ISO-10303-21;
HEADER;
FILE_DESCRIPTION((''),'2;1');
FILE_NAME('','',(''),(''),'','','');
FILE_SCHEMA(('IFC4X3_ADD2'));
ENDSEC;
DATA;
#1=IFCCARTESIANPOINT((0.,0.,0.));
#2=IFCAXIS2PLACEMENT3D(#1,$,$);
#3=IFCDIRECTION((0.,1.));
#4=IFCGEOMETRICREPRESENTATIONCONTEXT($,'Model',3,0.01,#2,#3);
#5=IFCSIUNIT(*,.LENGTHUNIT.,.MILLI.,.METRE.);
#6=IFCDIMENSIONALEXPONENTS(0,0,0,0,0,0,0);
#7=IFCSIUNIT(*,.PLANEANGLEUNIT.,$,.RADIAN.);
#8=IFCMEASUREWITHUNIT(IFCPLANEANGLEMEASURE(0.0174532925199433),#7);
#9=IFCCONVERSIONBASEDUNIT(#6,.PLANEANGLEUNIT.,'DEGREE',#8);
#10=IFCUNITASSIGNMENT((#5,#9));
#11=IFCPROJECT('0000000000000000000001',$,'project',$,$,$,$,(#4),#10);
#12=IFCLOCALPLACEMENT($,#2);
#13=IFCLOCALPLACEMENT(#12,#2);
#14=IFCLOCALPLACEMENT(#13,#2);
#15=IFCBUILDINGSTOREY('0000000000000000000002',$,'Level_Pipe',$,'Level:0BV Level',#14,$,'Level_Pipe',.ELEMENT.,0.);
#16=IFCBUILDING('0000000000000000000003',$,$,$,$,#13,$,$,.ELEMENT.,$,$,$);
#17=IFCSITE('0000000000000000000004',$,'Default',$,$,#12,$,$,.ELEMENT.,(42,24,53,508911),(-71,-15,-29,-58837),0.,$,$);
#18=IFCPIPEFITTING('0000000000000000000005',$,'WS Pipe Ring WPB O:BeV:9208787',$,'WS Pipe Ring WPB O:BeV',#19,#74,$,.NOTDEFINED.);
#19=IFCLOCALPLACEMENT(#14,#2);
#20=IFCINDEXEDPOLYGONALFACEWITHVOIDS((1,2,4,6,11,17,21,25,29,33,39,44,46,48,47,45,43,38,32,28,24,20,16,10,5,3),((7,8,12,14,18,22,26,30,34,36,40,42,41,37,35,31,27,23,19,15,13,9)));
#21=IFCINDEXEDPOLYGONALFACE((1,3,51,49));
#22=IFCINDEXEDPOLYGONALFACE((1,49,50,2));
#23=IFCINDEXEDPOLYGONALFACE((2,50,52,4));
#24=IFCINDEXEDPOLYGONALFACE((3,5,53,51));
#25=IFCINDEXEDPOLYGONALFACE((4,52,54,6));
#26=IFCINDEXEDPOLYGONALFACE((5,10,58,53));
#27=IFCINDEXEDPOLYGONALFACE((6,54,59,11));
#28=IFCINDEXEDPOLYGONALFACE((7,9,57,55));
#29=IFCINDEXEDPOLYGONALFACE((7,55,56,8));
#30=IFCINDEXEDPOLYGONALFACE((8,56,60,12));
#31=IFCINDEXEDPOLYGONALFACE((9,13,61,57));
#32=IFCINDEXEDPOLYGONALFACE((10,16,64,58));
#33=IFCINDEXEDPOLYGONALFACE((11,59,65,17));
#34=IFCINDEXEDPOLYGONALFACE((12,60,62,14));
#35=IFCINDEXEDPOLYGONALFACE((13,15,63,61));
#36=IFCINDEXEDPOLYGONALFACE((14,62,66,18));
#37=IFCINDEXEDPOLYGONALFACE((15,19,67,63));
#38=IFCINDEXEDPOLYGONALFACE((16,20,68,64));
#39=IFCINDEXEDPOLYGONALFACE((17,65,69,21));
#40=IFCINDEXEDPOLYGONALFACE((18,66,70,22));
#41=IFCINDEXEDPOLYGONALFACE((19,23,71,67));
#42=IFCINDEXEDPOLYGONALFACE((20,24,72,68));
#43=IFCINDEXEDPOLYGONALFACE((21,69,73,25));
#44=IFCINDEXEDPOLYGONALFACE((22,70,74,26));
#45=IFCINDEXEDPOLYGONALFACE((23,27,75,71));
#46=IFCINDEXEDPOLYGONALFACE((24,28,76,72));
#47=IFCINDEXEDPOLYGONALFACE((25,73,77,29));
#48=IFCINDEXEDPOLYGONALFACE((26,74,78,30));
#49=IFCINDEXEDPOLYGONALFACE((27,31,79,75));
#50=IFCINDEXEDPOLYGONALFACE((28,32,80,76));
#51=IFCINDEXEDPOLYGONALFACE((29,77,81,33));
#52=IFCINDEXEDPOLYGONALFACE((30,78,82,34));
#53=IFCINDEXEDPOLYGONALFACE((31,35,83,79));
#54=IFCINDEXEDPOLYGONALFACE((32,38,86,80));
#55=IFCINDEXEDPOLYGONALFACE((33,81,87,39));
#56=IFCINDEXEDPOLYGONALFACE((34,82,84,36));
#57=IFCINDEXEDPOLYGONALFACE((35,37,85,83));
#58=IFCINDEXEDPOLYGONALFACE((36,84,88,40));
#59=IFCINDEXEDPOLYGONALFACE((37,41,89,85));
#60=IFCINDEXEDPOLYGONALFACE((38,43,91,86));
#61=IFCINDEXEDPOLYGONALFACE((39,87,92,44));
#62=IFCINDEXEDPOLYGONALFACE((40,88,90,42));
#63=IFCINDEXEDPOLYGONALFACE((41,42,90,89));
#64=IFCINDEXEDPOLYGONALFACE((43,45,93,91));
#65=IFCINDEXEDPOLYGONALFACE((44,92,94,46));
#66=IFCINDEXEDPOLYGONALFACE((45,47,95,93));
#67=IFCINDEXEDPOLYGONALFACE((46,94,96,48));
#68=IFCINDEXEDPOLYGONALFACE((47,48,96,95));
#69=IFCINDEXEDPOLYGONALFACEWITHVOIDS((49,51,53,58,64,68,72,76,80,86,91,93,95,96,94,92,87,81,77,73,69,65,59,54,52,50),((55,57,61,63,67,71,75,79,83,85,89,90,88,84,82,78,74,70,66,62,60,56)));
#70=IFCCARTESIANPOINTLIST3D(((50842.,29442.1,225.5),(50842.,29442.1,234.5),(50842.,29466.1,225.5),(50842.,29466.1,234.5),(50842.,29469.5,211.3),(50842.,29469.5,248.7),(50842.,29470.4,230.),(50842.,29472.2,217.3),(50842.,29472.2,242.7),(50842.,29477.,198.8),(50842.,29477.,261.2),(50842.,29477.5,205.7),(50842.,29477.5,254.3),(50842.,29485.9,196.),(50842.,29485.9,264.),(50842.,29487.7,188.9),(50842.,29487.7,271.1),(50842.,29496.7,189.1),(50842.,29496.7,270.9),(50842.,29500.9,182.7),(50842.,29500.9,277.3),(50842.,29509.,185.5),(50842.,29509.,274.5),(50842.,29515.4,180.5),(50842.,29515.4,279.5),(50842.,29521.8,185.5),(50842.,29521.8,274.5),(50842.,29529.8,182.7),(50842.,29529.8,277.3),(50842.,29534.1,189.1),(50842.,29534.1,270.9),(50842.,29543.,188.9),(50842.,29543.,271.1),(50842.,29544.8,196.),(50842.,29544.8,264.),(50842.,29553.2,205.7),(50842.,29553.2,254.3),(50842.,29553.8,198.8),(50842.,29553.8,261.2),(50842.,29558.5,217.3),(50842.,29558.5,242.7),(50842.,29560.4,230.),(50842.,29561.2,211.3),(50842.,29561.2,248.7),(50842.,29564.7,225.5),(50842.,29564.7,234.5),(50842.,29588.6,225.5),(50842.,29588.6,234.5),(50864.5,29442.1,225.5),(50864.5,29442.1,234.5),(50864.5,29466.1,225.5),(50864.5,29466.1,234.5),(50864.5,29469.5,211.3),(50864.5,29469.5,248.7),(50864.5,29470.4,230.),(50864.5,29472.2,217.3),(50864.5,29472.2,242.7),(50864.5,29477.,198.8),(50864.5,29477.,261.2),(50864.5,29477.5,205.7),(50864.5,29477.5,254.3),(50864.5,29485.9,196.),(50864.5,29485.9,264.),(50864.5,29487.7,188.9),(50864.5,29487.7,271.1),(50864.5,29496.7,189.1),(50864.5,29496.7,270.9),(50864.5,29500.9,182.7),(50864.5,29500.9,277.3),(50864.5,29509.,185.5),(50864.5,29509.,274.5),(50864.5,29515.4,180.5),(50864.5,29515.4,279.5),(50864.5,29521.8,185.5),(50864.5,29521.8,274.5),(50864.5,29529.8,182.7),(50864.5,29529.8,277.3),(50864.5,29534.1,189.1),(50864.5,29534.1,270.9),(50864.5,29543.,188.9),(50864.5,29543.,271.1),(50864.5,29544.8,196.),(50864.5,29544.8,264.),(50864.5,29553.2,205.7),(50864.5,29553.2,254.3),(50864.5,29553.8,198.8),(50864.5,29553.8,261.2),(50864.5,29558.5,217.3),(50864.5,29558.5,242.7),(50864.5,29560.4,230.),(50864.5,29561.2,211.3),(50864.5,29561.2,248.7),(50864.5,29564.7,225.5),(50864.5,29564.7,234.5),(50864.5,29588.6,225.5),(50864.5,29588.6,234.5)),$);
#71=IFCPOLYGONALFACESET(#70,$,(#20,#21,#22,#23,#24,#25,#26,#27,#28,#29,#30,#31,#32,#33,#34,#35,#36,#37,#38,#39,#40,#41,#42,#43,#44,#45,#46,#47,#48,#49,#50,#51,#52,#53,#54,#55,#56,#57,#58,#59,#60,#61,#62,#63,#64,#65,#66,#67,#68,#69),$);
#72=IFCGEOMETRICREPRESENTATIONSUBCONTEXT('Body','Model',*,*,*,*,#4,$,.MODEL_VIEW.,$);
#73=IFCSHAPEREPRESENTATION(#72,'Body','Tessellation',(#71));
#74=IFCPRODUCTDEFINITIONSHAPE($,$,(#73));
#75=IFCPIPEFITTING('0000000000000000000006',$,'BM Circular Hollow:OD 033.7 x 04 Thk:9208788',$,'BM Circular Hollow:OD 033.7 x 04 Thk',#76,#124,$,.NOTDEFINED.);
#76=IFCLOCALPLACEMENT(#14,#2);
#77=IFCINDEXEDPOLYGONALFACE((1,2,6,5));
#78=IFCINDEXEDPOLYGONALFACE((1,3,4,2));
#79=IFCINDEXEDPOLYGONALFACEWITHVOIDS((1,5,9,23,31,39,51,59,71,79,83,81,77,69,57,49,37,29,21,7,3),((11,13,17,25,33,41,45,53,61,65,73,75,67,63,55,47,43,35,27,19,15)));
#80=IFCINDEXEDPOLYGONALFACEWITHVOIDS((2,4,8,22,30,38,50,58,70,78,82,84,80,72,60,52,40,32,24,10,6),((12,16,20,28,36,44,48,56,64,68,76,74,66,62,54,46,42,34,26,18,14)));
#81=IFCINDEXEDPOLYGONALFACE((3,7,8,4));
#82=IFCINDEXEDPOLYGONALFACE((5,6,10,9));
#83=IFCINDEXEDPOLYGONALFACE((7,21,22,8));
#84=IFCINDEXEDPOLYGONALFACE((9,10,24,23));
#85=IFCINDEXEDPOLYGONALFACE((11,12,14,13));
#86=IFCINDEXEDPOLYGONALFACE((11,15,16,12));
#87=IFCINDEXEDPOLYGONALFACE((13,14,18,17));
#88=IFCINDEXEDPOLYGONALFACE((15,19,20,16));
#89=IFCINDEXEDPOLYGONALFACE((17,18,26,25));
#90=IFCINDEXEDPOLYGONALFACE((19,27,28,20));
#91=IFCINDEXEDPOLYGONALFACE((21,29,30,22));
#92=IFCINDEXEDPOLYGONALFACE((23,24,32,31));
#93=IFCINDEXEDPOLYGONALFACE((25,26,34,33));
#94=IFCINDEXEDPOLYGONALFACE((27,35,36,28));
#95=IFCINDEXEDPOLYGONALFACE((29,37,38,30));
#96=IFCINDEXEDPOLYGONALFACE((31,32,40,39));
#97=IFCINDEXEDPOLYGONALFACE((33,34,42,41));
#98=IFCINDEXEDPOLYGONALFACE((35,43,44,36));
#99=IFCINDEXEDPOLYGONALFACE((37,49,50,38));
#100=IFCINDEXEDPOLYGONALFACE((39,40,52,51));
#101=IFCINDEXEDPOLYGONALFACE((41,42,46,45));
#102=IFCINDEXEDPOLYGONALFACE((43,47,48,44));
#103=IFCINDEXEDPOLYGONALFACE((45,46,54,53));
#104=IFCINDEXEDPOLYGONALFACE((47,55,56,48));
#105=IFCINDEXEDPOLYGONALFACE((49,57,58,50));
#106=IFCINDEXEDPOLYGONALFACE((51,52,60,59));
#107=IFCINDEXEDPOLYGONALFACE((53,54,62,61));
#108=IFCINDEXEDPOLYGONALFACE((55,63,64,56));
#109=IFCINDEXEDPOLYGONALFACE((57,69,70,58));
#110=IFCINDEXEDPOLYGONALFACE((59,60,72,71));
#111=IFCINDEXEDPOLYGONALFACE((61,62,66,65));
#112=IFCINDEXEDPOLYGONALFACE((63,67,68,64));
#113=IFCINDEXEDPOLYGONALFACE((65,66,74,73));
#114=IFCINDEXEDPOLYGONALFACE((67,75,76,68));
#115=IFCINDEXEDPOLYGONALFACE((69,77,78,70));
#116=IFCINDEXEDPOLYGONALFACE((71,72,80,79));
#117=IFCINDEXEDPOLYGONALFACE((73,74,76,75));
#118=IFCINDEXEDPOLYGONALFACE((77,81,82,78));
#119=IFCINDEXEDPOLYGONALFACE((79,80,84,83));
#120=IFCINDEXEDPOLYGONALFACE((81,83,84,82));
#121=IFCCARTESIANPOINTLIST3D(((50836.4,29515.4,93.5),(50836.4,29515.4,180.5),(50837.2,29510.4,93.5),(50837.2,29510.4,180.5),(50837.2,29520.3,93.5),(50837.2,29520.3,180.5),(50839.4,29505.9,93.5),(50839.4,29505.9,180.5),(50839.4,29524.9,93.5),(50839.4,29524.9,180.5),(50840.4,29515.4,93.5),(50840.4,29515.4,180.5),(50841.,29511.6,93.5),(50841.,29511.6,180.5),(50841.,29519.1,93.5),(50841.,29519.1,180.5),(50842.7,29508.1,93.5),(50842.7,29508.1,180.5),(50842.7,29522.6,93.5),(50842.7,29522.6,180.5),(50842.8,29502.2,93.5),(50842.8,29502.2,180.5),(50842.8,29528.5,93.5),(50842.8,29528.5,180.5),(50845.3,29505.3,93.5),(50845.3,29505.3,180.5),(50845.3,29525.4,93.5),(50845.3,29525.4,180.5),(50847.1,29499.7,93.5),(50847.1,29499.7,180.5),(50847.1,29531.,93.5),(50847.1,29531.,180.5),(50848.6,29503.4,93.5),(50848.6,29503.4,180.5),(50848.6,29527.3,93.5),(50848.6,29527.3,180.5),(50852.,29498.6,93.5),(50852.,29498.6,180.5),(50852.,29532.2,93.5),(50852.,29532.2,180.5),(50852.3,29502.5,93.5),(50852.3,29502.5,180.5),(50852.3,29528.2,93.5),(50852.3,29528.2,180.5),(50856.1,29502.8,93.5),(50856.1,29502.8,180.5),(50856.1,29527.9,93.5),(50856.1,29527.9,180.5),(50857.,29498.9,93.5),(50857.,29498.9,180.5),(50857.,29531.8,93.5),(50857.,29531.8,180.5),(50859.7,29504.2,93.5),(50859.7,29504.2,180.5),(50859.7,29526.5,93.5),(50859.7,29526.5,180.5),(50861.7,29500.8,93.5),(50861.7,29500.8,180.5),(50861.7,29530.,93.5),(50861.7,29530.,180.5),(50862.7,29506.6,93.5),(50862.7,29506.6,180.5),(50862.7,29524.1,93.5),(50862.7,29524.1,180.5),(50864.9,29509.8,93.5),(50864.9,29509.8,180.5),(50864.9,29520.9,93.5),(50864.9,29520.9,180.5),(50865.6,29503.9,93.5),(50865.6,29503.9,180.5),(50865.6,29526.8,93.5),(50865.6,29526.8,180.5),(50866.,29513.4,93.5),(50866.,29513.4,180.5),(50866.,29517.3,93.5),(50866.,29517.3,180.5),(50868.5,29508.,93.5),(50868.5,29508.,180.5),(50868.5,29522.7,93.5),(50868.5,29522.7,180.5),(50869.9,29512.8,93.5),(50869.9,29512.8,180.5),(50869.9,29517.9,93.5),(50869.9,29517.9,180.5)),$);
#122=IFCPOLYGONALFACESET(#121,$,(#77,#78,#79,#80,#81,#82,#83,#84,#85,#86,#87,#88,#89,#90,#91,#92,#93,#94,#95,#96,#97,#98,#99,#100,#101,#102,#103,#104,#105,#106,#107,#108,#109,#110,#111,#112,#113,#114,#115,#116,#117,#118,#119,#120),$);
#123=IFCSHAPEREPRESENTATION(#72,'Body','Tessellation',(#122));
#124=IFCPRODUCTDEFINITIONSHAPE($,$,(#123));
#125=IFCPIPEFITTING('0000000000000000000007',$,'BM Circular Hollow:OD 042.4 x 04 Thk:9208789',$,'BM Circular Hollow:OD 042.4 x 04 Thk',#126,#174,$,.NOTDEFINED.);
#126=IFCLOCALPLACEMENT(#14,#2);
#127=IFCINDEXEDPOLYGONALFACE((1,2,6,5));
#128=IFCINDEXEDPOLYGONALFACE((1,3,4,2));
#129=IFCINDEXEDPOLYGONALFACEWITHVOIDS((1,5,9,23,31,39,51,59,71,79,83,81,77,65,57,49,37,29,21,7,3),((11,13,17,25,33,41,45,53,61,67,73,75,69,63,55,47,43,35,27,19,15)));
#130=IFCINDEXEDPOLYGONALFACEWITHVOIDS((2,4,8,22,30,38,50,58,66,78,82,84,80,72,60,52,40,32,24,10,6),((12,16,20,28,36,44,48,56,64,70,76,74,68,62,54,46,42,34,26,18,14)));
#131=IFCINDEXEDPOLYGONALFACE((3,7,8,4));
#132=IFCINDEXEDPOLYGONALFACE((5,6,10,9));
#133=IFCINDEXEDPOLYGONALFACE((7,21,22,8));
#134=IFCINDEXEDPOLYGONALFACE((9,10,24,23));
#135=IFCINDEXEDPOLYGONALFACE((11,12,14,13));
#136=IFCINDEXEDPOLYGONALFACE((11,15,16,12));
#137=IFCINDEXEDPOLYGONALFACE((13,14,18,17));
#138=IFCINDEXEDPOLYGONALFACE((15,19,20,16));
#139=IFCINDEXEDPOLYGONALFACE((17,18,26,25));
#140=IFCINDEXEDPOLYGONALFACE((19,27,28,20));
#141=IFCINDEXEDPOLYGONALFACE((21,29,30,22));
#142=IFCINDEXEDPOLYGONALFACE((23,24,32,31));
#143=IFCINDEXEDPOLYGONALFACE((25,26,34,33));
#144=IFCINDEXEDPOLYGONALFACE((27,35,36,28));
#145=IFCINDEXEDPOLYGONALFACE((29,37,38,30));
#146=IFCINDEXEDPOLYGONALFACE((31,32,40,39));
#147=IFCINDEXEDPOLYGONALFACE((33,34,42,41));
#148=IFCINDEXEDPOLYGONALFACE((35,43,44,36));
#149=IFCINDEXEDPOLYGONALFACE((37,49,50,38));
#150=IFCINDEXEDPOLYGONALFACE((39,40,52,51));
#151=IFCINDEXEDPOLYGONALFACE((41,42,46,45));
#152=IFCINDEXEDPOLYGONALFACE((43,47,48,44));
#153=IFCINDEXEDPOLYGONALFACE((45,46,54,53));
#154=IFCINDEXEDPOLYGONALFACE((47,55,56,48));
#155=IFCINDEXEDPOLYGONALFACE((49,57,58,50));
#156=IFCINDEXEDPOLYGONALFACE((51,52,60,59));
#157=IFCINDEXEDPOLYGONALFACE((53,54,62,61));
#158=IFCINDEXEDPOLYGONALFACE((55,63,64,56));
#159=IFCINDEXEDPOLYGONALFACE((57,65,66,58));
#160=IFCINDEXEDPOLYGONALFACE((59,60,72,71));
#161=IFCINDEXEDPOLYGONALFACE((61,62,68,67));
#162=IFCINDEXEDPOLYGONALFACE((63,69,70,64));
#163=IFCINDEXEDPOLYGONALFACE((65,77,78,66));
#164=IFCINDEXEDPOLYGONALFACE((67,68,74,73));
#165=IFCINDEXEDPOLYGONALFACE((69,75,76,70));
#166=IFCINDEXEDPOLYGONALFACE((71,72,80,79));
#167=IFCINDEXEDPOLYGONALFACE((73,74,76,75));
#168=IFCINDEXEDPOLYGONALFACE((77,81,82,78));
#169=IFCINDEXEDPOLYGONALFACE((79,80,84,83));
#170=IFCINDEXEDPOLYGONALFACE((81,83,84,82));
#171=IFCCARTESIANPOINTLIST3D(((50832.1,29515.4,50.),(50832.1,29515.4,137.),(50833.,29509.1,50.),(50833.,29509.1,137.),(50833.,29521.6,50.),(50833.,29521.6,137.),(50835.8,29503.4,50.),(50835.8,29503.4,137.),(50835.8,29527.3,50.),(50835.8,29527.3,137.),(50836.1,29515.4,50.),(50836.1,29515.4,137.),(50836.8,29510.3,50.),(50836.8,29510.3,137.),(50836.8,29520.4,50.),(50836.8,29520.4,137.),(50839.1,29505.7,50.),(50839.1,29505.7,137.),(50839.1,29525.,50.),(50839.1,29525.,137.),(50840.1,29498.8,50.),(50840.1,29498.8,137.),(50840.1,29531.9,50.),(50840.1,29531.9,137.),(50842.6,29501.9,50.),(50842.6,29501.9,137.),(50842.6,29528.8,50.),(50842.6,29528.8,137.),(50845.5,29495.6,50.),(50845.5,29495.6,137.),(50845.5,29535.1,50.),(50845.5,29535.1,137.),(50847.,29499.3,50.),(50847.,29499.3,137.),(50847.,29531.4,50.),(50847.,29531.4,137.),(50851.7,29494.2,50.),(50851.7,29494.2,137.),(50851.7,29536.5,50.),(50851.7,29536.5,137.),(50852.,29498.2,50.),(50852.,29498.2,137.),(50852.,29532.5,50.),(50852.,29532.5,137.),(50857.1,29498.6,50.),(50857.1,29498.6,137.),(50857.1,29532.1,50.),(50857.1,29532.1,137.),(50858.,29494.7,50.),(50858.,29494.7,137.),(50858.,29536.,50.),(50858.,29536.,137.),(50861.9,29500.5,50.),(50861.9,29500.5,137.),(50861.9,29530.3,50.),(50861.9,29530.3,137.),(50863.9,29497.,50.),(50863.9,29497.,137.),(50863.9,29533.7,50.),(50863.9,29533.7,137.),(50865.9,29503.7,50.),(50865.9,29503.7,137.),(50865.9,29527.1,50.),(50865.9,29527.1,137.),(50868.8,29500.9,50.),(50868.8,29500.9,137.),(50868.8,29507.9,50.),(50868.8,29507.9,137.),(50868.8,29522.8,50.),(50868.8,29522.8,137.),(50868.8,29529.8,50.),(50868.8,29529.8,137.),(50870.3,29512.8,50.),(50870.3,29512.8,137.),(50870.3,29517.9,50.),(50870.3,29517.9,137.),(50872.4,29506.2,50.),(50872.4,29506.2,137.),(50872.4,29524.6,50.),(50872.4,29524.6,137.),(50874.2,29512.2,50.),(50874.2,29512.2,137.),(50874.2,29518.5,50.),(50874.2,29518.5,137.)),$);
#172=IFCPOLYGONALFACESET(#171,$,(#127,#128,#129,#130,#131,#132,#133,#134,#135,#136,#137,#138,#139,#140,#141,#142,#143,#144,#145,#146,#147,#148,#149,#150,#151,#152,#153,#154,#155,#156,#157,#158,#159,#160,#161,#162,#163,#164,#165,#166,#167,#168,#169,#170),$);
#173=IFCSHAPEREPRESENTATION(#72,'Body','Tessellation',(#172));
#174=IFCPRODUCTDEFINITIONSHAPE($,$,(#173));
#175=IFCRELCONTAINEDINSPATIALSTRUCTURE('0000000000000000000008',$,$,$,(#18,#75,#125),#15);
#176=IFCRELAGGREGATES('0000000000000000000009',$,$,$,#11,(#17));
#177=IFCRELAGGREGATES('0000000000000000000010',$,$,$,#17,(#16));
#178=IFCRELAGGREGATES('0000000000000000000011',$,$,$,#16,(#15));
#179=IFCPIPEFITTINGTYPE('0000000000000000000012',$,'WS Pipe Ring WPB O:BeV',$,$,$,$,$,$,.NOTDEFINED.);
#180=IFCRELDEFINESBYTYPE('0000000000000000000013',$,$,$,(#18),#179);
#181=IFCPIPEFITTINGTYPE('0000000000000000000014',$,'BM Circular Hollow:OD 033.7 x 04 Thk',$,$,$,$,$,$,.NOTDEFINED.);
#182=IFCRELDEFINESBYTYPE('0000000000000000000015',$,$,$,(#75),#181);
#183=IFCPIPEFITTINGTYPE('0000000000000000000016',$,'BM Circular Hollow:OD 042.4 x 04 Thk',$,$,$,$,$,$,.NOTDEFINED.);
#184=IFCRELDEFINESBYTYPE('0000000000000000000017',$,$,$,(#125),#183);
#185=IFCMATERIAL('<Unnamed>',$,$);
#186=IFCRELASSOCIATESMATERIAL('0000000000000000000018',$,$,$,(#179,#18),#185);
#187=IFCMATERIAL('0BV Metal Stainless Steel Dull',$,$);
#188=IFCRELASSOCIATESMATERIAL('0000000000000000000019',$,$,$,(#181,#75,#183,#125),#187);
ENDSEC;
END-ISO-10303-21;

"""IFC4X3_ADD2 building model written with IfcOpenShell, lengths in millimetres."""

from ifc_helpers import new_model, entity, si_unit, converted_unit, direction, frame, frame_2d, origin, origin_2d_with_axis, place, context, subcontext, project, spatial, polyline, circle_curve, parameter, trimmed, segment, composite_curve, hollow_circle, outline, extrude, source, transform, mapped, material, type_object, type_shapes, element, save


model = new_model("IFC4X3_ADD2")

# Units and contexts
model_context = context("Model", 3, precision=0.01, world=origin(), true_north=direction((0.0, 1.0)))
body_context = subcontext(model_context, "Body", "Model", "MODEL_VIEW")
ifc_project = project(units=[si_unit("LENGTHUNIT", "METRE", prefix="MILLI"), converted_unit("PLANEANGLEUNIT", "DEGREE", entity("IfcPlaneAngleMeasure", 0.0174532925199433), si_unit("PLANEANGLEUNIT", "RADIAN"), dimensions=[0, 0, 0, 0, 0, 0, 0])], contexts=[model_context])

# Site, building, storey
site_placement = place(None, origin())
site = spatial("IfcSite", under=ifc_project, at=site_placement, Name="Default", CompositionType="ELEMENT", RefLatitude=(42, 24, 53, 508911), RefLongitude=(-71, -15, -29, -58837), RefElevation=0.0)
building_placement = place(site_placement, origin())
building = spatial("IfcBuilding", under=site, at=building_placement, CompositionType="ELEMENT")
storey_placement = place(building_placement, origin())
storey = spatial("IfcBuildingStorey", under=building, at=storey_placement, Name="Level_Pipe", ObjectType="Level:0BV Level", LongName="Level_Pipe", CompositionType="ELEMENT", Elevation=0.0)

# Pipe fittings
ifc_material_1 = material(Name="0BV Metal Stainless Steel Dull")
ifc_material_2 = material(Name="<Unnamed>")
pipe_fitting_type_1 = type_object("IfcPipeFittingType", Name="WS Pipe Ring WPB O:BeV", PredefinedType="NOTDEFINED", material=ifc_material_2)
shared_shape_1 = source(origin(), body_context, "Body", "SweptSolid", [
    extrude(outline(composite_curve([segment(trimmed(circle_curve(origin_2d_with_axis(), 49.5), [parameter(185.215909)], [parameter(354.784091)], True, "PARAMETER"), True, "CONTINUOUS"), segment(polyline([(49.3, -4.5), (73.3, -4.5)]), True, "CONTINUOUS"), segment(polyline([(73.3, -4.5), (73.3, 4.5)]), True, "CONTINUOUS"), segment(polyline([(73.3, 4.5), (49.3, 4.5)]), True, "CONTINUOUS"), segment(trimmed(circle_curve(origin_2d_with_axis(), 49.5), [parameter(5.215909)], [parameter(174.784091)], True, "PARAMETER"), True, "CONTINUOUS"), segment(polyline([(-49.3, 4.5), (-73.3, 4.5)]), True, "CONTINUOUS"), segment(polyline([(-73.3, 4.5), (-73.3, -4.5)]), True, "CONTINUOUS"), segment(polyline([(-73.3, -4.5), (-49.3, -4.5)]), True, "CONTINUOUS")], self_intersect=False), holes=[composite_curve([segment(trimmed(circle_curve(origin_2d_with_axis(), 45.0), [parameter(0.0)], [parameter(180.0)], True, "PARAMETER"), False, "CONTINUOUS"), segment(trimmed(circle_curve(origin_2d_with_axis(), 45.0), [parameter(180.0)], [parameter(360.0)], True, "PARAMETER"), False, "CONTINUOUS")], self_intersect=False)]), frame((0.0, -11.2, 0.0), z_axis=(0.0, 1.0, 0.0), x_axis=(1.0, 0.0, 0.0)), (0.0, 0.0, 1.0), 22.5),
])
type_shapes(pipe_fitting_type_1, [shared_shape_1])
pipe_fitting_1_placement = place(storey_placement, frame((50853.3, 29515.4, 230.0), z_axis=(0.0, 0.0, 1.0), x_axis=(0.0, -1.0, 0.0)))
element("IfcPipeFitting", 1, at=pipe_fitting_1_placement, inside=storey, type_object=pipe_fitting_type_1, material=ifc_material_2, Name="WS Pipe Ring WPB O:BeV:9208787", ObjectType="WS Pipe Ring WPB O:BeV", PredefinedType="NOTDEFINED", context=body_context, shape_type="MappedRepresentation", body=[
    mapped(shared_shape_1, transform((0.0, 0.0, 0.0), scale=1.0)),
])
pipe_fitting_type_2 = type_object("IfcPipeFittingType", Name="BM Circular Hollow:OD 033.7 x 04 Thk", PredefinedType="NOTDEFINED", material=ifc_material_1)
shared_shape_2 = source(origin(), body_context, "Body", "SweptSolid", [
    extrude(hollow_circle(Radius=16.9, WallThickness=4.0, at=frame_2d((0.0, 0.0), x_axis=(1.0, 0.0))), frame((-43.5, 0.0, 0.0), z_axis=(1.0, 0.0, 0.0), x_axis=(0.0, -1.0, 0.0)), (0.0, 0.0, 1.0), 87.0),
])
type_shapes(pipe_fitting_type_2, [shared_shape_2])
pipe_fitting_2_placement = place(storey_placement, frame((50853.3, 29515.4, 137.0), z_axis=(0.0, 1.0, 0.0), x_axis=(0.0, 0.0, 1.0)))
element("IfcPipeFitting", 2, at=pipe_fitting_2_placement, inside=storey, type_object=pipe_fitting_type_2, material=ifc_material_1, Name="BM Circular Hollow:OD 033.7 x 04 Thk:9208788", ObjectType="BM Circular Hollow:OD 033.7 x 04 Thk", PredefinedType="NOTDEFINED", context=body_context, shape_type="MappedRepresentation", body=[
    mapped(shared_shape_2, transform((0.0, 0.0, 0.0), scale=1.0)),
])
pipe_fitting_type_3 = type_object("IfcPipeFittingType", Name="BM Circular Hollow:OD 042.4 x 04 Thk", PredefinedType="NOTDEFINED", material=ifc_material_1)
shared_shape_3 = source(origin(), body_context, "Body", "SweptSolid", [
    extrude(hollow_circle(Radius=21.2, WallThickness=4.0, at=frame_2d((0.0, 0.0), x_axis=(1.0, 0.0))), frame((-43.5, 0.0, 0.0), z_axis=(1.0, 0.0, 0.0), x_axis=(0.0, -1.0, 0.0)), (0.0, 0.0, 1.0), 87.0),
])
type_shapes(pipe_fitting_type_3, [shared_shape_3])
pipe_fitting_3_placement = place(storey_placement, frame((50853.3, 29515.4, 93.5), z_axis=(0.0, 1.0, 0.0), x_axis=(0.0, 0.0, 1.0)))
element("IfcPipeFitting", 3, at=pipe_fitting_3_placement, inside=storey, type_object=pipe_fitting_type_3, material=ifc_material_1, Name="BM Circular Hollow:OD 042.4 x 04 Thk:9208789", ObjectType="BM Circular Hollow:OD 042.4 x 04 Thk", PredefinedType="NOTDEFINED", context=body_context, shape_type="MappedRepresentation", body=[
    mapped(shared_shape_3, transform((0.0, 0.0, 0.0), scale=1.0)),
])

save(model, "model.ifc")
